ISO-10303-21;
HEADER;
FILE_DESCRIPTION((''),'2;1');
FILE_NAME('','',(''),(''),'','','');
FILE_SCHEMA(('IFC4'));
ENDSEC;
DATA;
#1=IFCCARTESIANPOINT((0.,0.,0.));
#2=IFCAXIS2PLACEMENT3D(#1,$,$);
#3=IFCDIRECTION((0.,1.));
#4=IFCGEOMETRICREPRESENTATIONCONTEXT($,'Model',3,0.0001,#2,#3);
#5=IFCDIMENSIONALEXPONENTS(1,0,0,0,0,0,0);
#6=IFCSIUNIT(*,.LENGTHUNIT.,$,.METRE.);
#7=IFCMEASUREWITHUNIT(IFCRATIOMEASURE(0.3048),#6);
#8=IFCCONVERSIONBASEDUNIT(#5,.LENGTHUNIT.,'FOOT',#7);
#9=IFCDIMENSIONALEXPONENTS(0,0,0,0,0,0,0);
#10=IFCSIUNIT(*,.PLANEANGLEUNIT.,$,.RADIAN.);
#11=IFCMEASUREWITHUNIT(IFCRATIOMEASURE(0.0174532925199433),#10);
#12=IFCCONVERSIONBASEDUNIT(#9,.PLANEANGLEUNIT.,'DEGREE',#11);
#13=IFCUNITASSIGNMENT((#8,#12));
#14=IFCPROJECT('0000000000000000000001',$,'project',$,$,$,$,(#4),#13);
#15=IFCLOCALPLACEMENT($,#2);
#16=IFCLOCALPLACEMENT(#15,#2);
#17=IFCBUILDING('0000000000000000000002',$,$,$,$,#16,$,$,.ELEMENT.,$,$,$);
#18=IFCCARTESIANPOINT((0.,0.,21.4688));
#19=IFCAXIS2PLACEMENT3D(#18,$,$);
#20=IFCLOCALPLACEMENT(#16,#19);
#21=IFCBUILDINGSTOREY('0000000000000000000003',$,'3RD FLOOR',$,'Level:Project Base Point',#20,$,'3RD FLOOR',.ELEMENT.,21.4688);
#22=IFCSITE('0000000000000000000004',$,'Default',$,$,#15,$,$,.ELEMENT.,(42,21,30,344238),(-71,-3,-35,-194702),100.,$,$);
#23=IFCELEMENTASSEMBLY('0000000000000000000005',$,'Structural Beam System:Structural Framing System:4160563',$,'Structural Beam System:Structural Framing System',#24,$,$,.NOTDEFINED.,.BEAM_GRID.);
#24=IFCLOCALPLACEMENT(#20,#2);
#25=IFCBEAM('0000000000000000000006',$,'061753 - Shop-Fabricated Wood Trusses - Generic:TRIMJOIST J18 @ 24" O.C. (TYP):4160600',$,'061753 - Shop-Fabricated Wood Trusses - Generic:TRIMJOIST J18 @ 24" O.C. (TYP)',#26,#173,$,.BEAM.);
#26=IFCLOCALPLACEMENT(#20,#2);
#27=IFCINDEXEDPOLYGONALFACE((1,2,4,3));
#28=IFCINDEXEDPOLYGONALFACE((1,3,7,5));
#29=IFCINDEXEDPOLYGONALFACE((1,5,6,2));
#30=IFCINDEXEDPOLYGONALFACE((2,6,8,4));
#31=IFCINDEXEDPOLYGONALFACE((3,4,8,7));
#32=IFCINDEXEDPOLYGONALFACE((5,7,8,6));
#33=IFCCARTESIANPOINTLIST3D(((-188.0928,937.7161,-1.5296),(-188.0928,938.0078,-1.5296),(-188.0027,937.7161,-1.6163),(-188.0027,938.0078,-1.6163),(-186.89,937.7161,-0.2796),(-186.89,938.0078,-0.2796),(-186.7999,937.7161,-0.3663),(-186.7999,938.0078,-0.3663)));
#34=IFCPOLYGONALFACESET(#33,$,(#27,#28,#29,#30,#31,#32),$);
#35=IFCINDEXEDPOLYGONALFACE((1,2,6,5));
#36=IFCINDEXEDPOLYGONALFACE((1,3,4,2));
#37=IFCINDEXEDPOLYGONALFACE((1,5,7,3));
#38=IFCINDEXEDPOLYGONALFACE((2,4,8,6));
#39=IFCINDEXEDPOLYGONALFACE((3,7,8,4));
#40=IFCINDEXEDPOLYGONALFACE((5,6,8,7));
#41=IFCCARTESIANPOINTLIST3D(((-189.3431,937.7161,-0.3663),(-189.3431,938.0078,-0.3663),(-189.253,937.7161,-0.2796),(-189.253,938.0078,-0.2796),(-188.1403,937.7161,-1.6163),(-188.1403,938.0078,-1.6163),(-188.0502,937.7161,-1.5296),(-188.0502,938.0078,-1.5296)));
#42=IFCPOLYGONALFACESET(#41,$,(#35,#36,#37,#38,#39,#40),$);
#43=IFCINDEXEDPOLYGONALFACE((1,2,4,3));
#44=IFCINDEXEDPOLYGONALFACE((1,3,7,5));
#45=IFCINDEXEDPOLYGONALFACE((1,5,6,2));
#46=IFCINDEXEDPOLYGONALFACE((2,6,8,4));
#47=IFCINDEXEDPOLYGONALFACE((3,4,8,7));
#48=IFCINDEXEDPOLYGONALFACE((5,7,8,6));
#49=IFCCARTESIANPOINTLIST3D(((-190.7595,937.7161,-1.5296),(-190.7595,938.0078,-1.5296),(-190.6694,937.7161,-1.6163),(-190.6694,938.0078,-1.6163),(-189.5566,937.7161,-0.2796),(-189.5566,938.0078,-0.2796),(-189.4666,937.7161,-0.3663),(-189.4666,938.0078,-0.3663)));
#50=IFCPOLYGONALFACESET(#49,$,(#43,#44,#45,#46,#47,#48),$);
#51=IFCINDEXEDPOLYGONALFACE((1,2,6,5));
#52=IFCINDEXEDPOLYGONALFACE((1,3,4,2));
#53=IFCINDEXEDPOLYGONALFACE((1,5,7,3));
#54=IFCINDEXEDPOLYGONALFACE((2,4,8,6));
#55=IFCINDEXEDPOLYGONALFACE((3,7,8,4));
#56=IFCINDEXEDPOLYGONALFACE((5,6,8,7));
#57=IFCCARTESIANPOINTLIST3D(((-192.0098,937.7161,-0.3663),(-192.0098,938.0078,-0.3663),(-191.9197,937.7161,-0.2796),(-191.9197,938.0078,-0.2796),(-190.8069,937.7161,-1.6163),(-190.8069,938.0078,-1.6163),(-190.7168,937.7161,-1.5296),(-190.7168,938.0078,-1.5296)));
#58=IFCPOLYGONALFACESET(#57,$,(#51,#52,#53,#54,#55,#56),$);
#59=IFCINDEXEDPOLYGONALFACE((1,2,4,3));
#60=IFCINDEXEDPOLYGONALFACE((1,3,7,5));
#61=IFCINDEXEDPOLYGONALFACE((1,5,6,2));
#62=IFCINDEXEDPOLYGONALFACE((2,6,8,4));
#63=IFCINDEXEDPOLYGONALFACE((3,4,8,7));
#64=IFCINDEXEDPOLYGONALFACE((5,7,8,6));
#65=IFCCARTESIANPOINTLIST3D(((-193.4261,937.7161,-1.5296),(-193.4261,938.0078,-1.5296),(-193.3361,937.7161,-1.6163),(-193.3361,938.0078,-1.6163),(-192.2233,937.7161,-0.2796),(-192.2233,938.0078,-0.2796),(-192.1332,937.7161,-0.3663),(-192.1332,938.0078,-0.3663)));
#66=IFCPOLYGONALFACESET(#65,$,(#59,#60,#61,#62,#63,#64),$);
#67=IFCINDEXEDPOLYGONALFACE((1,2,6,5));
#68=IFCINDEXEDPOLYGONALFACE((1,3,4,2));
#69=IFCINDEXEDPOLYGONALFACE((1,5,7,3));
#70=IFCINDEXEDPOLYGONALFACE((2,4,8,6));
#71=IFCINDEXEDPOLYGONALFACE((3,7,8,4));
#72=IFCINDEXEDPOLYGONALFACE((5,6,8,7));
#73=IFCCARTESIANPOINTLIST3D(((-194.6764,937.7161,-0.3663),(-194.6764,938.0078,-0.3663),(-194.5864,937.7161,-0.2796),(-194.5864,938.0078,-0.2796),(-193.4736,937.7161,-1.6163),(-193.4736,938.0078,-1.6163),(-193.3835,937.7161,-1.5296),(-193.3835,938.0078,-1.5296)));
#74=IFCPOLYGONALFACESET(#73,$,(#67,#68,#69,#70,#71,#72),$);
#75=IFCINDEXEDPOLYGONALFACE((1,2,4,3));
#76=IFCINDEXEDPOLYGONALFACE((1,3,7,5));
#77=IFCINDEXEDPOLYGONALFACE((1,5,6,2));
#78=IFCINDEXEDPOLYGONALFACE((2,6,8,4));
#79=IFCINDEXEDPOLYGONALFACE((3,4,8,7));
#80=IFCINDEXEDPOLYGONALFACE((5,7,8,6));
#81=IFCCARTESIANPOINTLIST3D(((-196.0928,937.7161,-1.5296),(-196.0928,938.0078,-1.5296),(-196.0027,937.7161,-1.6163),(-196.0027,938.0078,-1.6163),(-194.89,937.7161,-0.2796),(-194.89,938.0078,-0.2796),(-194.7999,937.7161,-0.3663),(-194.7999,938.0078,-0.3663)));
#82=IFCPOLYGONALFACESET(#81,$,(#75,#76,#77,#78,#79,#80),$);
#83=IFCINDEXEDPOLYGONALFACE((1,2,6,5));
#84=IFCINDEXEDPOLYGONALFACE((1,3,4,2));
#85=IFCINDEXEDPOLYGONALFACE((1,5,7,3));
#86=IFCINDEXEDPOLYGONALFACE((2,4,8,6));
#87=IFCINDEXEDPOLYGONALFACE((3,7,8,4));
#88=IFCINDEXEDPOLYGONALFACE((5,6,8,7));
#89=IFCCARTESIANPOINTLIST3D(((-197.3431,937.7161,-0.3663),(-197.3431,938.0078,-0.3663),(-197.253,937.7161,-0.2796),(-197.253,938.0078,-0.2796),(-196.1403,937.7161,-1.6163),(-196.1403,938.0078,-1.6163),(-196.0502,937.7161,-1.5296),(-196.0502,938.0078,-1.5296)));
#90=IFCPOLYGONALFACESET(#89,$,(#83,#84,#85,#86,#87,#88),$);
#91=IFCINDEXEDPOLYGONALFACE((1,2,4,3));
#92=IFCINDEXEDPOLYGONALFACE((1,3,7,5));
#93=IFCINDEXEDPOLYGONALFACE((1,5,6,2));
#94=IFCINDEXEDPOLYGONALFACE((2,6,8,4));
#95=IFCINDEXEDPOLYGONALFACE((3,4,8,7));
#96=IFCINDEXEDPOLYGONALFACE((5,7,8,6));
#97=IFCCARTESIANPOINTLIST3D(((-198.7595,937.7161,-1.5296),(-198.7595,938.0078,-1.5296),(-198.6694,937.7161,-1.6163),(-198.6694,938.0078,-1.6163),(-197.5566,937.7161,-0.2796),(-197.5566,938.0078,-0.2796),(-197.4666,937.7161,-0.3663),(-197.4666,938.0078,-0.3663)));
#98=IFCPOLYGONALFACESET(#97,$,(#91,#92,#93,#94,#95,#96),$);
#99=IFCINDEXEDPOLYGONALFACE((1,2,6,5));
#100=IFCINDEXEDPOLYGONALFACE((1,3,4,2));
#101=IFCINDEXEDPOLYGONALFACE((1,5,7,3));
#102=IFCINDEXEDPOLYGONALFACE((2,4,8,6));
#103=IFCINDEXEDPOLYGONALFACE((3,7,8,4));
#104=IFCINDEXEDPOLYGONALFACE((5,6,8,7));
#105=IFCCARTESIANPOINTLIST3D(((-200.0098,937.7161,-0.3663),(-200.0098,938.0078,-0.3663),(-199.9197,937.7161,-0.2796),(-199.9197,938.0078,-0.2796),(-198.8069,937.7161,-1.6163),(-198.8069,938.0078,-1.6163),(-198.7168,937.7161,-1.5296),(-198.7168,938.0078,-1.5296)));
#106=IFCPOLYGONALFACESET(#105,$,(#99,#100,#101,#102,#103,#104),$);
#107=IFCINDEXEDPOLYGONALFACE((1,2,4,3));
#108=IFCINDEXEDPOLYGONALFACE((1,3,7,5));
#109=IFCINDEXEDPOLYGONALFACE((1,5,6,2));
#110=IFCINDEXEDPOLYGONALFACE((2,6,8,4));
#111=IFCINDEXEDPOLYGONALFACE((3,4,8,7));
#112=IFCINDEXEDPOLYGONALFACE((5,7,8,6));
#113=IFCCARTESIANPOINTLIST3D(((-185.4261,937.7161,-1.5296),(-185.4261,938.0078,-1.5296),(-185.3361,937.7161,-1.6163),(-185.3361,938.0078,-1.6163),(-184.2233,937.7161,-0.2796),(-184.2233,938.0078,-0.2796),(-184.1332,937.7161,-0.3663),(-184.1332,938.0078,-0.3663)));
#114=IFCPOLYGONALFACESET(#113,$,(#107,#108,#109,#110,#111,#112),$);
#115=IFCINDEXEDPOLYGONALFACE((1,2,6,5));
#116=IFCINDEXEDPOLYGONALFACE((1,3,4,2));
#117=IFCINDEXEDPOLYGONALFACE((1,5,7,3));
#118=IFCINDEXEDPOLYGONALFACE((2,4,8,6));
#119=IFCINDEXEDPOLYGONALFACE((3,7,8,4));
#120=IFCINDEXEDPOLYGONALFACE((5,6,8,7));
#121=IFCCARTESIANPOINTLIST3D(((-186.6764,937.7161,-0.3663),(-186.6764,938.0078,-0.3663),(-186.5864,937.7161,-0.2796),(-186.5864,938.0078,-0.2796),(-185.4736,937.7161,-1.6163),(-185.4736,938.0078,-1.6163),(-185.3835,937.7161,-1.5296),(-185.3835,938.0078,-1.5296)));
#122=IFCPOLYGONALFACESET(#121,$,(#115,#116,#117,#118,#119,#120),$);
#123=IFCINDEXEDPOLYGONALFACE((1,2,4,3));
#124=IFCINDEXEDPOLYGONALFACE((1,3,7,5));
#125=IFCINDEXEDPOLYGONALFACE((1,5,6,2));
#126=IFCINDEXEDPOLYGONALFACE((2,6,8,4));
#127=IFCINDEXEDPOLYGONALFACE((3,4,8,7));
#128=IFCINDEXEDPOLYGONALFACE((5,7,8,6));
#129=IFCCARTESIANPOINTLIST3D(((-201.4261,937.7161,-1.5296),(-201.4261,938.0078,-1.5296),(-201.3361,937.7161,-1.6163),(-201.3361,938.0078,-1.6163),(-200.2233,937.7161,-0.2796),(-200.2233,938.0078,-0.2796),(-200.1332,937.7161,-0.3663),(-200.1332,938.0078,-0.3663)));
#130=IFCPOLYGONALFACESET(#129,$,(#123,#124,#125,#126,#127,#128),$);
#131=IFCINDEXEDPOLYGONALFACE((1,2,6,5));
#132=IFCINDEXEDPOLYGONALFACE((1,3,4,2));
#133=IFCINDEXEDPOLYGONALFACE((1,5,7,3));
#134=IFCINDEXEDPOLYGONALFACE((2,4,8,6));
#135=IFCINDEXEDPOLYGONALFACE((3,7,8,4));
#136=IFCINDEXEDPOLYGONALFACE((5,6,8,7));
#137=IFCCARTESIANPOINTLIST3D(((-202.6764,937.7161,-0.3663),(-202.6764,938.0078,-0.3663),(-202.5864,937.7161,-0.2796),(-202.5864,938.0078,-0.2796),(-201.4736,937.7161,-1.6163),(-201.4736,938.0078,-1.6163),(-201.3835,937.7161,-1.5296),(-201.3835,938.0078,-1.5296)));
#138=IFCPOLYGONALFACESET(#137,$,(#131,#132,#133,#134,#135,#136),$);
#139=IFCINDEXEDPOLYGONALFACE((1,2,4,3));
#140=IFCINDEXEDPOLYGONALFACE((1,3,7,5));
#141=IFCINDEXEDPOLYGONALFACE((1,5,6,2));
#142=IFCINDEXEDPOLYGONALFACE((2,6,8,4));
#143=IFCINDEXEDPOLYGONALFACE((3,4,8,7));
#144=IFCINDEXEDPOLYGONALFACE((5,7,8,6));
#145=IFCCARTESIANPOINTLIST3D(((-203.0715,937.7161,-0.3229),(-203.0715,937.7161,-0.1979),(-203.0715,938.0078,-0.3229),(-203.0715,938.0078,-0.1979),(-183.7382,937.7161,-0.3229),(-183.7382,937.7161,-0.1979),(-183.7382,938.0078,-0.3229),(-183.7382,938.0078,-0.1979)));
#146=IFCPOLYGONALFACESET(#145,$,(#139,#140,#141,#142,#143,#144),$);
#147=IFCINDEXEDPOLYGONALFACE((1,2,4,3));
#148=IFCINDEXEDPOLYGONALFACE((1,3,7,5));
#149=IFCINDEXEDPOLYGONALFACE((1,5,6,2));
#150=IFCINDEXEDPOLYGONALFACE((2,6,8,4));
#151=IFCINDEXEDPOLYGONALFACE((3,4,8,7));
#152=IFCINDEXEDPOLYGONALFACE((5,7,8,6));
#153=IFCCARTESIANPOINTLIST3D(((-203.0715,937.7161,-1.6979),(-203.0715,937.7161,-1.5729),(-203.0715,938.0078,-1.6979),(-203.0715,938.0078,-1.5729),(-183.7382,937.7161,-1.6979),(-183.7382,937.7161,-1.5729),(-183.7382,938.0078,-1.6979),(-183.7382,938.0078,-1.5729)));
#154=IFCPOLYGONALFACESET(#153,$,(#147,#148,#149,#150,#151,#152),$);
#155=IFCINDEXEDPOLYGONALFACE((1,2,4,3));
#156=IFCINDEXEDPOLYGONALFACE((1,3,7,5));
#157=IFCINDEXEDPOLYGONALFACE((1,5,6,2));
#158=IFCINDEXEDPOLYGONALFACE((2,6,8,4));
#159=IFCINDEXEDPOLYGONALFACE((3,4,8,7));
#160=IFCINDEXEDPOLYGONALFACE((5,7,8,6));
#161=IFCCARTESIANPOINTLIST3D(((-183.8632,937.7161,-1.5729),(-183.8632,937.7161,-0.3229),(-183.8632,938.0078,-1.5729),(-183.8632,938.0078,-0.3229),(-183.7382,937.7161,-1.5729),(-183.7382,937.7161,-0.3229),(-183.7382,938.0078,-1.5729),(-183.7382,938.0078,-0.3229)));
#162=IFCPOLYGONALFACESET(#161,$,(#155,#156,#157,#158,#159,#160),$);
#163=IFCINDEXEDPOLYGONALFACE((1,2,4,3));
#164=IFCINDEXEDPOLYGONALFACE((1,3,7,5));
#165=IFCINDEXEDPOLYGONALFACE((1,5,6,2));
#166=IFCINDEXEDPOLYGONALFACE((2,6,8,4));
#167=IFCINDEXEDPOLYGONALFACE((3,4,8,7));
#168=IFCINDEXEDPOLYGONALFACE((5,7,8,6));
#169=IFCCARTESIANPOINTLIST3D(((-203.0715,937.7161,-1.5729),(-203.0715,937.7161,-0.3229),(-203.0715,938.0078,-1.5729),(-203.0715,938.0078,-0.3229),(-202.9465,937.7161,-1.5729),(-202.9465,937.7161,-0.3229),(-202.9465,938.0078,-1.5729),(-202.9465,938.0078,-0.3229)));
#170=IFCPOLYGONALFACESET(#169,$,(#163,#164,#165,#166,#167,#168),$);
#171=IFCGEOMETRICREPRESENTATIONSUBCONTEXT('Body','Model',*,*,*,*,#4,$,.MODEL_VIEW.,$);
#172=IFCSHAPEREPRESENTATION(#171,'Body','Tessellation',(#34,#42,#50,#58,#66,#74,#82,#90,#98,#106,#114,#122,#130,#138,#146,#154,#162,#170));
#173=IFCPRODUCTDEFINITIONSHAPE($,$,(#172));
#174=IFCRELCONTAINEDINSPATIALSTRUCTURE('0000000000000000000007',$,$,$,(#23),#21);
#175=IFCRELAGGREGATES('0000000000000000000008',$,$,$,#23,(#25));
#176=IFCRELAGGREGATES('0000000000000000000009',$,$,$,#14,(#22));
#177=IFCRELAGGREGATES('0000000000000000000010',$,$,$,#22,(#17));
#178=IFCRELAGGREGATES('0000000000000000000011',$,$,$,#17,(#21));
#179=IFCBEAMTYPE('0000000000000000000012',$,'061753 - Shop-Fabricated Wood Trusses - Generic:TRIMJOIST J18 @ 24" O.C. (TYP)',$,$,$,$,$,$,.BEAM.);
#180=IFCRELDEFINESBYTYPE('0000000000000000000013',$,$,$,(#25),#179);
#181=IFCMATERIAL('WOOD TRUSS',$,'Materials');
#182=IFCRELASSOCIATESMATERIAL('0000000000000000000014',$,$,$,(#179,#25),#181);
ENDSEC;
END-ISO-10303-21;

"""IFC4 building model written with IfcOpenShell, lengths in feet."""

from ifc_helpers import new_model, entity, si_unit, converted_unit, direction, frame, frame_2d, origin, origin_2d_with_axis, place, context, subcontext, project, spatial, rectangle, extrude, source, transform, mapped, material, material_profile, profile_set, profile_usage, type_object, type_shapes, element, aggregate, save


model = new_model("IFC4")

# Units and contexts
model_context = context("Model", 3, precision=0.0001, world=origin(), true_north=direction((0.0, 1.0)))
body_context = subcontext(model_context, "Body", "Model", "MODEL_VIEW")
ifc_project = project(units=[converted_unit("LENGTHUNIT", "FOOT", entity("IfcRatioMeasure", 0.3048), si_unit("LENGTHUNIT", "METRE"), dimensions=[1, 0, 0, 0, 0, 0, 0]), converted_unit("PLANEANGLEUNIT", "DEGREE", entity("IfcRatioMeasure", 0.0174532925199433), si_unit("PLANEANGLEUNIT", "RADIAN"), dimensions=[0, 0, 0, 0, 0, 0, 0])], contexts=[model_context])

# Site, building, storey
site_placement = place(None, origin())
site = spatial("IfcSite", under=ifc_project, at=site_placement, Name="Default", CompositionType="ELEMENT", RefLatitude=(42, 21, 30, 344238), RefLongitude=(-71, -3, -35, -194702), RefElevation=100.0)
building_placement = place(site_placement, origin())
building = spatial("IfcBuilding", under=site, at=building_placement, CompositionType="ELEMENT")
storey_placement = place(building_placement, frame((0.0, 0.0, 21.4688)))
storey = spatial("IfcBuildingStorey", under=building, at=storey_placement, Name="3RD FLOOR", ObjectType="Level:Project Base Point", LongName="3RD FLOOR", CompositionType="ELEMENT", Elevation=21.4688)

# Element assembly, beam
ifc_material = material(Name="WOOD TRUSS", Category="Materials")
ifc_material_profile_1 = material_profile(ifc_material, rectangle(XDim=1.7347, YDim=0.125, at=frame_2d((0.0, 0.0), x_axis=(1.0, 0.0))), Name="TRIMJOIST J18 @ 24\" O.C. (TYP)")
ifc_material_profile_2 = material_profile(ifc_material, rectangle(XDim=1.7347, YDim=0.125, at=frame_2d((0.0, 0.0), x_axis=(1.0, 0.0))), Name="TRIMJOIST J18 @ 24\" O.C. (TYP)")
ifc_material_profile_3 = material_profile(ifc_material, rectangle(XDim=1.7347, YDim=0.125, at=frame_2d((0.0, 0.0), x_axis=(1.0, 0.0))), Name="TRIMJOIST J18 @ 24\" O.C. (TYP)")
ifc_material_profile_4 = material_profile(ifc_material, rectangle(XDim=1.7347, YDim=0.125, at=frame_2d((0.0, 0.0), x_axis=(1.0, 0.0))), Name="TRIMJOIST J18 @ 24\" O.C. (TYP)")
ifc_material_profile_5 = material_profile(ifc_material, rectangle(XDim=1.7347, YDim=0.125, at=frame_2d((0.0, 0.0), x_axis=(1.0, 0.0))), Name="TRIMJOIST J18 @ 24\" O.C. (TYP)")
ifc_material_profile_6 = material_profile(ifc_material, rectangle(XDim=1.7347, YDim=0.125, at=frame_2d((0.0, 0.0), x_axis=(1.0, 0.0))), Name="TRIMJOIST J18 @ 24\" O.C. (TYP)")
ifc_material_profile_7 = material_profile(ifc_material, rectangle(XDim=1.7347, YDim=0.125, at=frame_2d((0.0, 0.0), x_axis=(1.0, 0.0))), Name="TRIMJOIST J18 @ 24\" O.C. (TYP)")
ifc_material_profile_8 = material_profile(ifc_material, rectangle(XDim=1.7347, YDim=0.125, at=frame_2d((0.0, 0.0), x_axis=(1.0, 0.0))), Name="TRIMJOIST J18 @ 24\" O.C. (TYP)")
ifc_material_profile_9 = material_profile(ifc_material, rectangle(XDim=1.7347, YDim=0.125, at=frame_2d((0.0, 0.0), x_axis=(1.0, 0.0))), Name="TRIMJOIST J18 @ 24\" O.C. (TYP)")
ifc_material_profile_10 = material_profile(ifc_material, rectangle(XDim=1.7347, YDim=0.125, at=origin_2d_with_axis()), Name="TRIMJOIST J18 @ 24\" O.C. (TYP)")
ifc_material_profile_11 = material_profile(ifc_material, rectangle(XDim=0.125, YDim=0.2917, at=origin_2d_with_axis()), Name="TRIMJOIST J18 @ 24\" O.C. (TYP)")
ifc_material_profile_12 = material_profile(ifc_material, rectangle(XDim=0.125, YDim=0.2917, at=origin_2d_with_axis()), Name="TRIMJOIST J18 @ 24\" O.C. (TYP)")
ifc_material_profile_13 = material_profile(ifc_material, rectangle(XDim=1.25, YDim=0.2917, at=origin_2d_with_axis()), Name="TRIMJOIST J18 @ 24\" O.C. (TYP)")
ifc_material_profile_14 = material_profile(ifc_material, rectangle(XDim=1.25, YDim=0.2917, at=origin_2d_with_axis()), Name="TRIMJOIST J18 @ 24\" O.C. (TYP)")
ifc_profile_set = profile_set([ifc_material_profile_1, ifc_material_profile_2, ifc_material_profile_3, ifc_material_profile_4, ifc_material_profile_5, ifc_material_profile_6, ifc_material_profile_7, ifc_material_profile_8, ifc_material_profile_9, ifc_material_profile_10, ifc_material_profile_11, ifc_material_profile_12, ifc_material_profile_13, ifc_material_profile_14], Name="TRIMJOIST J18 @ 24\" O.C. (TYP)")
beam_type_1 = type_object("IfcBeamType", Name="061753 - Shop-Fabricated Wood Trusses - Generic:TRIMJOIST J18 @ 24\" O.C. (TYP)", PredefinedType="BEAM", material=ifc_profile_set)
shared_shape_1 = source(origin(), body_context, "Body", "SweptSolid", [
    extrude(rectangle(XDim=1.7347, YDim=0.125, at=frame_2d((0.0, 0.0), x_axis=(1.0, 0.0))), frame((5.9585, -0.1458, 0.0), z_axis=(0.0, 1.0, 0.0), x_axis=(0.693383, 0.0, 0.720569)), (0.0, 0.0, 1.0), 0.2917),
    extrude(rectangle(XDim=1.7347, YDim=0.125, at=origin_2d_with_axis()), frame((4.7082, -0.1458, 0.0), z_axis=(0.0, 1.0, 0.0), x_axis=(0.693383, 0.0, -0.720569)), (0.0, 0.0, 1.0), 0.2917),
    extrude(rectangle(XDim=1.7347, YDim=0.125, at=frame_2d((0.0, 0.0), x_axis=(1.0, 0.0))), frame((3.2918, -0.1458, 0.0), z_axis=(0.0, 1.0, 0.0), x_axis=(0.693383, 0.0, 0.720569)), (0.0, 0.0, 1.0), 0.2917),
    extrude(rectangle(XDim=1.7347, YDim=0.125, at=frame_2d((0.0, 0.0), x_axis=(1.0, 0.0))), frame((2.0415, -0.1458, 0.0), z_axis=(0.0, 1.0, 0.0), x_axis=(0.693383, 0.0, -0.720569)), (0.0, 0.0, 1.0), 0.2917),
    extrude(rectangle(XDim=1.7347, YDim=0.125, at=frame_2d((0.0, 0.0), x_axis=(1.0, 0.0))), frame((0.6251, -0.1458, 0.0), z_axis=(0.0, 1.0, 0.0), x_axis=(0.693383, 0.0, 0.720569)), (0.0, 0.0, 1.0), 0.2917),
    extrude(rectangle(XDim=1.7347, YDim=0.125, at=frame_2d((0.0, 0.0), x_axis=(1.0, 0.0))), frame((-0.6251, -0.1458, 0.0), z_axis=(0.0, 1.0, 0.0), x_axis=(0.693383, 0.0, -0.720569)), (0.0, 0.0, 1.0), 0.2917),
    extrude(rectangle(XDim=1.7347, YDim=0.125, at=frame_2d((0.0, 0.0), x_axis=(1.0, 0.0))), frame((-2.0415, -0.1458, 0.0), z_axis=(0.0, 1.0, 0.0), x_axis=(0.693383, 0.0, 0.720569)), (0.0, 0.0, 1.0), 0.2917),
    extrude(rectangle(XDim=1.7347, YDim=0.125, at=origin_2d_with_axis()), frame((-3.2918, -0.1458, 0.0), z_axis=(0.0, 1.0, 0.0), x_axis=(0.693383, 0.0, -0.720569)), (0.0, 0.0, 1.0), 0.2917),
    extrude(rectangle(XDim=1.7347, YDim=0.125, at=frame_2d((0.0, 0.0), x_axis=(1.0, 0.0))), frame((-4.7082, -0.1458, 0.0), z_axis=(0.0, 1.0, 0.0), x_axis=(0.693383, 0.0, 0.720569)), (0.0, 0.0, 1.0), 0.2917),
    extrude(rectangle(XDim=1.7347, YDim=0.125, at=frame_2d((0.0, 0.0), x_axis=(1.0, 0.0))), frame((-5.9585, -0.1458, 0.0), z_axis=(0.0, 1.0, 0.0), x_axis=(0.693383, 0.0, -0.720569)), (0.0, 0.0, 1.0), 0.2917),
    extrude(rectangle(XDim=1.7347, YDim=0.125, at=frame_2d((0.0, 0.0), x_axis=(1.0, 0.0))), frame((8.6251, -0.1458, 0.0), z_axis=(0.0, 1.0, 0.0), x_axis=(0.693383, 0.0, 0.720569)), (0.0, 0.0, 1.0), 0.2917),
    extrude(rectangle(XDim=1.7347, YDim=0.125, at=origin_2d_with_axis()), frame((7.3749, -0.1458, 0.0), z_axis=(0.0, 1.0, 0.0), x_axis=(0.693383, 0.0, -0.720569)), (0.0, 0.0, 1.0), 0.2917),
    extrude(rectangle(XDim=1.7347, YDim=0.125, at=frame_2d((0.0, 0.0), x_axis=(1.0, 0.0))), frame((-7.3749, -0.1458, 0.0), z_axis=(0.0, 1.0, 0.0), x_axis=(0.693383, 0.0, 0.720569)), (0.0, 0.0, 1.0), 0.2917),
    extrude(rectangle(XDim=1.7347, YDim=0.125, at=origin_2d_with_axis()), frame((-8.6251, -0.1458, 0.0), z_axis=(0.0, 1.0, 0.0), x_axis=(0.693383, 0.0, -0.720569)), (0.0, 0.0, 1.0), 0.2917),
    extrude(rectangle(XDim=0.125, YDim=0.2917, at=origin_2d_with_axis()), frame((-9.6667, 0.0, 0.6875), z_axis=(1.0, 0.0, 0.0), x_axis=(0.0, 0.0, -1.0)), (0.0, 0.0, 1.0), 19.3333),
    extrude(rectangle(XDim=0.125, YDim=0.2917, at=origin_2d_with_axis()), frame((-9.6667, 0.0, -0.6875), z_axis=(1.0, 0.0, 0.0), x_axis=(0.0, 0.0, -1.0)), (0.0, 0.0, 1.0), 19.3333),
    extrude(rectangle(XDim=1.25, YDim=0.2917, at=origin_2d_with_axis()), frame((9.5417, 0.0, 0.0), z_axis=(1.0, 0.0, 0.0), x_axis=(0.0, 0.0, -1.0)), (0.0, 0.0, 1.0), 0.125),
    extrude(rectangle(XDim=1.25, YDim=0.2917, at=origin_2d_with_axis()), frame((-9.6667, 0.0, 0.0), z_axis=(1.0, 0.0, 0.0), x_axis=(0.0, 0.0, -1.0)), (0.0, 0.0, 1.0), 0.125),
])
type_shapes(beam_type_1, [shared_shape_1])
assembly_1_placement = place(storey_placement, origin())
assembly_1 = element("IfcElementAssembly", 1, at=assembly_1_placement, inside=storey, Name="Structural Beam System:Structural Framing System:4160563", ObjectType="Structural Beam System:Structural Framing System", AssemblyPlace="NOTDEFINED", PredefinedType="BEAM_GRID")
ifc_profile_usage_1 = profile_usage(ifc_profile_set, cardinal=8)
beam_1_placement = place(assembly_1_placement, frame((-193.4048, 937.8619, -0.9479)))
beam_1 = element("IfcBeam", 2, at=beam_1_placement, type_object=beam_type_1, material=ifc_profile_usage_1, Name="061753 - Shop-Fabricated Wood Trusses - Generic:TRIMJOIST J18 @ 24\" O.C. (TYP):4160600", ObjectType="061753 - Shop-Fabricated Wood Trusses - Generic:TRIMJOIST J18 @ 24\" O.C. (TYP)", PredefinedType="BEAM", context=body_context, shape_type="MappedRepresentation", body=[
    mapped(shared_shape_1, transform((0.0, 0.0, 0.0), scale=1.0)),
])
aggregate(assembly_1, [beam_1])

save(model, "model.ifc")
